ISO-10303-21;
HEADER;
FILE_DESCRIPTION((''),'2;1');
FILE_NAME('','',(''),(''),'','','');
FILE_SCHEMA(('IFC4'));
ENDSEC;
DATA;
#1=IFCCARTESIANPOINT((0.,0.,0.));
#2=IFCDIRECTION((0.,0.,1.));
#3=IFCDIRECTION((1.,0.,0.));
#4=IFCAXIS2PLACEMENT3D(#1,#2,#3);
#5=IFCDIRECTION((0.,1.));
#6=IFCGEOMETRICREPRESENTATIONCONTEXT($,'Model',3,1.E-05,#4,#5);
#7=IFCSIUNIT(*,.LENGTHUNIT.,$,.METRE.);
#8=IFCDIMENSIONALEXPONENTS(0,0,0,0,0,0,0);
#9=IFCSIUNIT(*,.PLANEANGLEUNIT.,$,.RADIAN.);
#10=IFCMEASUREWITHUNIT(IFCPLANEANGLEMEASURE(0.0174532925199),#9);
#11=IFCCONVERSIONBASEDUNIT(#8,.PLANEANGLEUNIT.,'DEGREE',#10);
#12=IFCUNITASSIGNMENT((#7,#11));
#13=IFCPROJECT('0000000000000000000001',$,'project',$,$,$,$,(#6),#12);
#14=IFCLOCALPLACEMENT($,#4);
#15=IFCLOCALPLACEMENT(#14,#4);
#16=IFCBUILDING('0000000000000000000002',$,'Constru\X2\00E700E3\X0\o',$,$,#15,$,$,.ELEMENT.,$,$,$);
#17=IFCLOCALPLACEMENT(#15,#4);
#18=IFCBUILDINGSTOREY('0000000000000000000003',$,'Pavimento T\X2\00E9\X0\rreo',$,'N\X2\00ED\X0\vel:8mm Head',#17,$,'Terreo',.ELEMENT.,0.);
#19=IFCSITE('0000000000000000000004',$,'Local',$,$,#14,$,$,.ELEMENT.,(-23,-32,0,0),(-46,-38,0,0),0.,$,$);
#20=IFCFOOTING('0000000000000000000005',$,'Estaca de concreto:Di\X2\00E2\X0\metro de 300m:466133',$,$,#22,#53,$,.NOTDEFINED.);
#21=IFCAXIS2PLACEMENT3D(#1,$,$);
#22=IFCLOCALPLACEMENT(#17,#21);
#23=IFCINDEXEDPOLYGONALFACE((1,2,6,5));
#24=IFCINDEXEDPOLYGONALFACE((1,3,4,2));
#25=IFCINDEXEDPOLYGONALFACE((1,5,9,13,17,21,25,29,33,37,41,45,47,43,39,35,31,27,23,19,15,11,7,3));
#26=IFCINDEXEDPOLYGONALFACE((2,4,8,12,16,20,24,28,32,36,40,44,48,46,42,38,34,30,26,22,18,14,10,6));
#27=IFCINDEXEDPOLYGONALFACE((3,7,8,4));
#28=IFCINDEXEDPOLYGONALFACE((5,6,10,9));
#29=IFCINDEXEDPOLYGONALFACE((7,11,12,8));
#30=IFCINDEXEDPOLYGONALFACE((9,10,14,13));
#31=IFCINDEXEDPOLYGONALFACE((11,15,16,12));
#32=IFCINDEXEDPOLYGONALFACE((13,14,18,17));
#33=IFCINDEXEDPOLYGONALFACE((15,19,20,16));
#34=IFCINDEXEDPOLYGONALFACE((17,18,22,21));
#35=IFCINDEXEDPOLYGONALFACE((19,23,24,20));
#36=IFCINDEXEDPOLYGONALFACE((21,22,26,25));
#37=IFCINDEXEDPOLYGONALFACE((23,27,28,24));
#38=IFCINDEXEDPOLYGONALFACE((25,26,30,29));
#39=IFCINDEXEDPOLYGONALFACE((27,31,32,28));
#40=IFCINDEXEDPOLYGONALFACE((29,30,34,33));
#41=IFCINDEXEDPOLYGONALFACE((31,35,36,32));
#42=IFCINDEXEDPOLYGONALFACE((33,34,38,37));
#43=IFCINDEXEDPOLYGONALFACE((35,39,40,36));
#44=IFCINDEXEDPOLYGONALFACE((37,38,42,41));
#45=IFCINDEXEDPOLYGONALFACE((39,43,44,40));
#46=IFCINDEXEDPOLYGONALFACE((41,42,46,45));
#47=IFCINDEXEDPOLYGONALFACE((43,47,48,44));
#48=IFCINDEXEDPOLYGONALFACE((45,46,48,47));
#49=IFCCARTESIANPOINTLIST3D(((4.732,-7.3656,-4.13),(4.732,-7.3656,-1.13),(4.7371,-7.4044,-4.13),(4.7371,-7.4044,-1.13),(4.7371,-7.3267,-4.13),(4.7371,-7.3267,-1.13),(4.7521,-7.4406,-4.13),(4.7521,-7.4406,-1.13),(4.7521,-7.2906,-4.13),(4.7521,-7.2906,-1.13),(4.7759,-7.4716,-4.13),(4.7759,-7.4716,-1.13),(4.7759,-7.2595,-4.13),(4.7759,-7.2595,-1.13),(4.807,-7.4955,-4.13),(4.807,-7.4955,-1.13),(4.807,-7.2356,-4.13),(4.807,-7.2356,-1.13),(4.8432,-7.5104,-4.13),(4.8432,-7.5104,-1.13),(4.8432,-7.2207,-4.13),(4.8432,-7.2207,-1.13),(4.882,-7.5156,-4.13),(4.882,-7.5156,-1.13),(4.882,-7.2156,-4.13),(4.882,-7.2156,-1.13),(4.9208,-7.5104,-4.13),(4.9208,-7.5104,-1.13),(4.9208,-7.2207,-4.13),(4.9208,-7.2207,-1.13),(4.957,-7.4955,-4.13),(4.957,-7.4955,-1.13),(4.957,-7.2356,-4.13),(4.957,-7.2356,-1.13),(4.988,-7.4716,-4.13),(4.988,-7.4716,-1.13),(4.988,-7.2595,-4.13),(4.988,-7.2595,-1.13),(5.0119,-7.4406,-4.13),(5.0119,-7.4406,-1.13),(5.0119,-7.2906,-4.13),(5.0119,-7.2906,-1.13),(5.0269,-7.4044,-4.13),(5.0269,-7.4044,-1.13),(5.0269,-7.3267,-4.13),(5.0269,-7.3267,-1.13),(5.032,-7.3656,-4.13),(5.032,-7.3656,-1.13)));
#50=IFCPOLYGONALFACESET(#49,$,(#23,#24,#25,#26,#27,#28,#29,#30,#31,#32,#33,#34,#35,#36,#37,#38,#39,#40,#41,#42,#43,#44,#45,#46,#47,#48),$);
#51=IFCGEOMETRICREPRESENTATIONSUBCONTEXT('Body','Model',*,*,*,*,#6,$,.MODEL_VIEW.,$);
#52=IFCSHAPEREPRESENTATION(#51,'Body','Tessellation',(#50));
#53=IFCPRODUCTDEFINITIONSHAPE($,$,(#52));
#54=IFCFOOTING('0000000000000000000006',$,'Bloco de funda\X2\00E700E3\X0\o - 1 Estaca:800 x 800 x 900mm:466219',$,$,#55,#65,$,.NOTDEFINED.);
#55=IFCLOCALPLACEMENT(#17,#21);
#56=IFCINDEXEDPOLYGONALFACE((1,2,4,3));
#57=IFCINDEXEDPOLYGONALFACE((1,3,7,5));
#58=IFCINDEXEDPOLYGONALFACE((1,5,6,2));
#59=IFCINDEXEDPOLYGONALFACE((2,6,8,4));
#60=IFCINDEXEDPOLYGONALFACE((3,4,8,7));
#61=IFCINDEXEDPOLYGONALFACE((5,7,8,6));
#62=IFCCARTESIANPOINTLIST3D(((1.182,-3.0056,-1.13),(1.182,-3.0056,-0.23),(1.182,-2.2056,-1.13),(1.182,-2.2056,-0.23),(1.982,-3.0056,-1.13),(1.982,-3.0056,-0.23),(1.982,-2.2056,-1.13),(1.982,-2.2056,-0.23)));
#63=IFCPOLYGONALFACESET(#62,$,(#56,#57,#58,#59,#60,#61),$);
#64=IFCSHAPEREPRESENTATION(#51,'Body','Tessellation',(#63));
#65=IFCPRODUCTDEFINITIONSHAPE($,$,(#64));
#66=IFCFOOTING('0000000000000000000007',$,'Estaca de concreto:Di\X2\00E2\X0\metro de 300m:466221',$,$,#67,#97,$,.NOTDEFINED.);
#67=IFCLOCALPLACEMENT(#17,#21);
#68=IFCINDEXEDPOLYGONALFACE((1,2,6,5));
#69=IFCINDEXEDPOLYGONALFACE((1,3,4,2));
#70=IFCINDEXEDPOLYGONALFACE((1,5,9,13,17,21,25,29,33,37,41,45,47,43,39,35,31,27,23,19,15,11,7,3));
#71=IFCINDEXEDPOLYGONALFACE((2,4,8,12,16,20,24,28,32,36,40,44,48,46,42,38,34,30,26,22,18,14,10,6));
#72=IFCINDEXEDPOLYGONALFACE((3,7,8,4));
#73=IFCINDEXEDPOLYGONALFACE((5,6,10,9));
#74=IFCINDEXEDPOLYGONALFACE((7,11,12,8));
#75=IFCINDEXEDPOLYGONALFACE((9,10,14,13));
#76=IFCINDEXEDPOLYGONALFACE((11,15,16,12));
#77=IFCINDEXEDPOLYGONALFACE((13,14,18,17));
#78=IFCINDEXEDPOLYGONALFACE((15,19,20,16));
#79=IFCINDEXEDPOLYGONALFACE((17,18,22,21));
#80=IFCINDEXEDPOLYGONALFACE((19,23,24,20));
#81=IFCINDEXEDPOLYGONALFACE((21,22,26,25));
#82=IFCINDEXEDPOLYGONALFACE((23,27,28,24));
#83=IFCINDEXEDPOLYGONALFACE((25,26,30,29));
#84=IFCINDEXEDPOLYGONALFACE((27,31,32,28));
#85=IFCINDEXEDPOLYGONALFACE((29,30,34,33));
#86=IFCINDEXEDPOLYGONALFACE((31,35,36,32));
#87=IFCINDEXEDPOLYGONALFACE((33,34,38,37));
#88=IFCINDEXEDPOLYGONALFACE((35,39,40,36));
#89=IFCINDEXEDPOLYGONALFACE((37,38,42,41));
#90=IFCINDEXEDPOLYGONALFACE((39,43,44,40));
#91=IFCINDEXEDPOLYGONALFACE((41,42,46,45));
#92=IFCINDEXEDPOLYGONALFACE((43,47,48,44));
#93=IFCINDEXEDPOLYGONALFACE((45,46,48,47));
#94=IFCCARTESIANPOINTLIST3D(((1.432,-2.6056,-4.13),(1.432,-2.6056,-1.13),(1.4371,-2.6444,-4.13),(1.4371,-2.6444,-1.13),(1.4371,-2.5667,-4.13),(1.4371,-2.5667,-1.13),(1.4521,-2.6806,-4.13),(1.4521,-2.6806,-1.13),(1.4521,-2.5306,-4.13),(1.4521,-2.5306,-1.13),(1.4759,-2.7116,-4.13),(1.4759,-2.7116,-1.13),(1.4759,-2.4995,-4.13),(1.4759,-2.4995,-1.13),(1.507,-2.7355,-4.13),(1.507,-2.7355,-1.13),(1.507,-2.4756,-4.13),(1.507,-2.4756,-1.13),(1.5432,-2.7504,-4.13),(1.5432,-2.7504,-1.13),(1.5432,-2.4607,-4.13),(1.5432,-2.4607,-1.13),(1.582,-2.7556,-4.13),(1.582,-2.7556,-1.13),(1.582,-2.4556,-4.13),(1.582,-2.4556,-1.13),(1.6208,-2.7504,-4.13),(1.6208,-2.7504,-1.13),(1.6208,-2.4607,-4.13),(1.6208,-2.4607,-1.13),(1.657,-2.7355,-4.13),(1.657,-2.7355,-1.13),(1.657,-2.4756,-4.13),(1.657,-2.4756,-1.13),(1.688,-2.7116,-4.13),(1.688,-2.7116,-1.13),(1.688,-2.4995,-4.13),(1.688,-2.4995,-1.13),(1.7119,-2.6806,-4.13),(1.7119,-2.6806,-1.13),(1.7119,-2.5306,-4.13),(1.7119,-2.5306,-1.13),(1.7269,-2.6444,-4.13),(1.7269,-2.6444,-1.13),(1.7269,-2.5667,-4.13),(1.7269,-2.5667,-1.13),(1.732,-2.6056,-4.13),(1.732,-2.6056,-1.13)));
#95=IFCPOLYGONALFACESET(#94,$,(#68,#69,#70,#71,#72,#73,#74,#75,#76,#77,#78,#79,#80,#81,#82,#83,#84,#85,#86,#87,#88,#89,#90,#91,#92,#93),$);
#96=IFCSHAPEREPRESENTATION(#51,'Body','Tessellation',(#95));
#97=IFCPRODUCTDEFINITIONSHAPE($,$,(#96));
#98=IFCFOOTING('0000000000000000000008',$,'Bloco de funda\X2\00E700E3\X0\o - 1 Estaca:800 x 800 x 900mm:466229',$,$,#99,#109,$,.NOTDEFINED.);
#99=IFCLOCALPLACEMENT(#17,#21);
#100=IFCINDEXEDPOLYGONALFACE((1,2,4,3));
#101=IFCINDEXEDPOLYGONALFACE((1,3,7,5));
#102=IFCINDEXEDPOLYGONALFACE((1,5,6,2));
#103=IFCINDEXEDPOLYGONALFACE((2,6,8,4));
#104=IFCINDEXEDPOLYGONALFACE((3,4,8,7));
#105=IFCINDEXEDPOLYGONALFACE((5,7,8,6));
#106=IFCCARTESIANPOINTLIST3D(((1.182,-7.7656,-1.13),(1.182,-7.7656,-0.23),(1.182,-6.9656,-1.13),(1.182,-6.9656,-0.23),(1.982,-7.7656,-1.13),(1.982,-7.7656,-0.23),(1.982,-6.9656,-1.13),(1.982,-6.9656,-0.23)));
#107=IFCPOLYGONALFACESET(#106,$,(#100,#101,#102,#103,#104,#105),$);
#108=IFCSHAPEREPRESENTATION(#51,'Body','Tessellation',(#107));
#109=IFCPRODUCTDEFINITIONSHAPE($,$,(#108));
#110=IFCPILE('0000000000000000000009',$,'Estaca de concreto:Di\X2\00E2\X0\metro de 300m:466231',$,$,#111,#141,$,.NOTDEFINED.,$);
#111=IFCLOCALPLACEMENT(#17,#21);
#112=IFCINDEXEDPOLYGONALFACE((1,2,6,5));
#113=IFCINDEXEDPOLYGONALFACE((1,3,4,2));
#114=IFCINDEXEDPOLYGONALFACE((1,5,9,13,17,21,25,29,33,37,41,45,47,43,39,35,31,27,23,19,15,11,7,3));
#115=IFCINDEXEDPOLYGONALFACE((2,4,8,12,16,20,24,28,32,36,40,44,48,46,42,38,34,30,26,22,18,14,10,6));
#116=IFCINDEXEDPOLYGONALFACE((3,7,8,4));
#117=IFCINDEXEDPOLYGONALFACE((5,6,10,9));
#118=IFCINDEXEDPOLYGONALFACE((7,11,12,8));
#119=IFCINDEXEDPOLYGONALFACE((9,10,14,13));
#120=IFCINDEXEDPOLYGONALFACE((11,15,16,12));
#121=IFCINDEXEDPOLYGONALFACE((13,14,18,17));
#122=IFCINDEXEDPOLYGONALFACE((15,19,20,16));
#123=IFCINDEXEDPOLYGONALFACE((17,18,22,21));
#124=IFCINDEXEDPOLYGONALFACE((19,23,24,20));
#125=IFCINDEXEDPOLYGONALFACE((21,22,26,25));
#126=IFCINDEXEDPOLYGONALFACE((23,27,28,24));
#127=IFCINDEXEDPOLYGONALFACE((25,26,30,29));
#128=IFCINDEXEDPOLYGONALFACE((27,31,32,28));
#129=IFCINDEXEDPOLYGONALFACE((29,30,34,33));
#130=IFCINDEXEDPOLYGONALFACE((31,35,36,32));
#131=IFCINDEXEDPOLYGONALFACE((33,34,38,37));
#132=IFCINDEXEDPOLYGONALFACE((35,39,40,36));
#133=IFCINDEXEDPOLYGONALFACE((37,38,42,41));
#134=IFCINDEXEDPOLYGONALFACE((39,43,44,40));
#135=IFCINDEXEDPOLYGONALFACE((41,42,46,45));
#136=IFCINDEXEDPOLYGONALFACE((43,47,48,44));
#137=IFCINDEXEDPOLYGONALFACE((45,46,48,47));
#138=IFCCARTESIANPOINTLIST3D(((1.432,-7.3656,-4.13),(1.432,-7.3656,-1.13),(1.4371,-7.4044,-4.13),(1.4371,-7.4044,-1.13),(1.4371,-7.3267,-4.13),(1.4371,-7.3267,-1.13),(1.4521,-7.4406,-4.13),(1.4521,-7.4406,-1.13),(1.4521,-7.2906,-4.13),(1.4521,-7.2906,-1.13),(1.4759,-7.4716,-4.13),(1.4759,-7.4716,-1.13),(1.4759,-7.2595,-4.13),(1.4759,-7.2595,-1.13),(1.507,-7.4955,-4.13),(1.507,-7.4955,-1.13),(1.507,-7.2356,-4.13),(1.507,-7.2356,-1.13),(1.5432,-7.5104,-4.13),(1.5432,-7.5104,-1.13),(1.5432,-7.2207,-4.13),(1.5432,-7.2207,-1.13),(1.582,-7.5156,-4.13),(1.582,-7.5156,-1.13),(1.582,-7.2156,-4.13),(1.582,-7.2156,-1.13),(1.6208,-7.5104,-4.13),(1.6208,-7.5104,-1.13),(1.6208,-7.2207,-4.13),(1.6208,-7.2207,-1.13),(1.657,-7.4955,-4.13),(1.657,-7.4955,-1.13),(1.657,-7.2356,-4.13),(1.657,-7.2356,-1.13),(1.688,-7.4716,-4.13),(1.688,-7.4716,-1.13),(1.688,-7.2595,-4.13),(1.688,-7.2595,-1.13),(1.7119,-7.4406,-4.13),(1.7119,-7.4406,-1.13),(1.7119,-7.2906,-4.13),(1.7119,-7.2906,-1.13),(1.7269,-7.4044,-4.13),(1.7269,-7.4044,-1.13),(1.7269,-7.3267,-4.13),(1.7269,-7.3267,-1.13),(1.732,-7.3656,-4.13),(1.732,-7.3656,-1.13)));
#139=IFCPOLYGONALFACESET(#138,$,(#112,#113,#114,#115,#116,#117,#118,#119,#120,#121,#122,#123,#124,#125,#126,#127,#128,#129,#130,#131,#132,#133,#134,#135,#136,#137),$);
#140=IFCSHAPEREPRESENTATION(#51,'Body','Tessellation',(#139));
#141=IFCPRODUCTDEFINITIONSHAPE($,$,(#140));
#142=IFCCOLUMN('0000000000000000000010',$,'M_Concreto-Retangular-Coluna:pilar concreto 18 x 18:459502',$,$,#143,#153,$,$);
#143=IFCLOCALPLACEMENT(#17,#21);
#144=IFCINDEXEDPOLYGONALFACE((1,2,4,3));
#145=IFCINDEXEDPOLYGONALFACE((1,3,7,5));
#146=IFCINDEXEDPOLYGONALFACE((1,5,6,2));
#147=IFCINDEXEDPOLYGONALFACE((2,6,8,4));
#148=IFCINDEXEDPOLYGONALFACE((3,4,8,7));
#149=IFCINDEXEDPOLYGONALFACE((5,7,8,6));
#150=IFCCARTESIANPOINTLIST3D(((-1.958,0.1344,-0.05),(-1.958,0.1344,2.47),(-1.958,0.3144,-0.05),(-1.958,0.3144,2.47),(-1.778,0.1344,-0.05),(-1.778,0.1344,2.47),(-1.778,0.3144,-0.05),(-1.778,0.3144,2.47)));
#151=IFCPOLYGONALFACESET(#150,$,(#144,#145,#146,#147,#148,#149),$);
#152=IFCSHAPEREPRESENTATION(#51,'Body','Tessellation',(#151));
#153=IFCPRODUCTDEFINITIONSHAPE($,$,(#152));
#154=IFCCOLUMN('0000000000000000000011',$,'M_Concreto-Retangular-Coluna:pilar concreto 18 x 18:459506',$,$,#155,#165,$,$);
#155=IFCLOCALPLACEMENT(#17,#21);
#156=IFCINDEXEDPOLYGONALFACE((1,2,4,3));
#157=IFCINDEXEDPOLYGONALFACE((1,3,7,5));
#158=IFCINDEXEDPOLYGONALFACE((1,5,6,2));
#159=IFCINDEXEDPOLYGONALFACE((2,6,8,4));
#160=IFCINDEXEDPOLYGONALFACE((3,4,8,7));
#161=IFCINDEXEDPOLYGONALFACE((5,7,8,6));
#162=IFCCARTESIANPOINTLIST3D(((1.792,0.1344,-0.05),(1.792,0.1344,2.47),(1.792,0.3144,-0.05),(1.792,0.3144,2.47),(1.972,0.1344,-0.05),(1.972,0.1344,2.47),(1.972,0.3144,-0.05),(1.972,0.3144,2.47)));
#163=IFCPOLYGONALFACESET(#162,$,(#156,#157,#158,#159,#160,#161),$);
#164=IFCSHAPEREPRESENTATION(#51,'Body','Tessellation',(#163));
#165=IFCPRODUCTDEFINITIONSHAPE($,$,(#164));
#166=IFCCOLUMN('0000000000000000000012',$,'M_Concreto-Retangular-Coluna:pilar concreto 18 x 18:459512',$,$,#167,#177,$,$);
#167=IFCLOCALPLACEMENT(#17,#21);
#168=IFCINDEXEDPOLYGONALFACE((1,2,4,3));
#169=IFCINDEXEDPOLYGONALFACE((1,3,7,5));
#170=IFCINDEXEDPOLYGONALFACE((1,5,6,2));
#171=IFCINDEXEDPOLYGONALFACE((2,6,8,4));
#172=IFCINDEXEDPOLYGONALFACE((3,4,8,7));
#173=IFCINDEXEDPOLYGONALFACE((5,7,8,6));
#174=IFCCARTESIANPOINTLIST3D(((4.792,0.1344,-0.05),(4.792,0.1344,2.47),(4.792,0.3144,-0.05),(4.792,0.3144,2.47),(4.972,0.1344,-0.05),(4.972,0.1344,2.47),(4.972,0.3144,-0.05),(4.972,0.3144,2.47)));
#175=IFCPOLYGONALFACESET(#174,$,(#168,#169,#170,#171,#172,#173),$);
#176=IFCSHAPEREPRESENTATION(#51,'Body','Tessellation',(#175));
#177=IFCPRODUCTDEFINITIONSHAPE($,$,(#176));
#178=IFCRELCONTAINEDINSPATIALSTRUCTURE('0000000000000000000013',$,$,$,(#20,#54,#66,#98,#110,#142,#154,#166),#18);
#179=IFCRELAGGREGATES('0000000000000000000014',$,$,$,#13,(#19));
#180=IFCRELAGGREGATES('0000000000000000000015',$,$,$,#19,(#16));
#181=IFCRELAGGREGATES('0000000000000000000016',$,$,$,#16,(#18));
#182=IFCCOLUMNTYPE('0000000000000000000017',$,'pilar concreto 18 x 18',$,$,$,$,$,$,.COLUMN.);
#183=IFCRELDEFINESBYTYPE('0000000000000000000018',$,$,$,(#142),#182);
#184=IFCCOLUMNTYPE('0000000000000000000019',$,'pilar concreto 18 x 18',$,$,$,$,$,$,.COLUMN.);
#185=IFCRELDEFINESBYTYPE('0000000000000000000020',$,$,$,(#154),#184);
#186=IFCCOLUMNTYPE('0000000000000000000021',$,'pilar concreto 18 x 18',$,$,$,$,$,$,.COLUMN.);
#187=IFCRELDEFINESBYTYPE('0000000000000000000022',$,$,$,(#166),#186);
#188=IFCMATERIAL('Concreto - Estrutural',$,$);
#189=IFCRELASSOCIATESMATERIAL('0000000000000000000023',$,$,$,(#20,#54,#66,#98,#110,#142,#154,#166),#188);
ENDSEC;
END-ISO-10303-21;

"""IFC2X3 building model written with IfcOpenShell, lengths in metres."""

from ifc_helpers import new_model, entity, si_unit, converted_unit, point, direction, frame, frame_2d, origin_with_axes, origin_2d_with_axis, place, context, subcontext, project, spatial, polyline, circle_curve, parameter, trimmed, segment, composite_curve, rectangle, outline, extrude, material, type_object, element, save


model = new_model("IFC2X3")

# Units and contexts
model_context = context("Model", 3, precision=1e-05, world=origin_with_axes(), true_north=direction((0.0, 1.0)))
body_context = subcontext(model_context, "Body", "Model", "MODEL_VIEW")
ifc_project = project(units=[si_unit("LENGTHUNIT", "METRE"), converted_unit("PLANEANGLEUNIT", "DEGREE", entity("IfcPlaneAngleMeasure", 0.0174532925199), si_unit("PLANEANGLEUNIT", "RADIAN"), dimensions=[0, 0, 0, 0, 0, 0, 0])], contexts=[model_context])

# Site, building, storey
site_placement = place(None, origin_with_axes())
site = spatial("IfcSite", under=ifc_project, at=site_placement, Name="Local", CompositionType="ELEMENT", RefLatitude=(-23, -32, 0, 0), RefLongitude=(-46, -38, 0, 0), RefElevation=0.0)
building_placement = place(site_placement, origin_with_axes())
building = spatial("IfcBuilding", under=site, at=building_placement, Name="Construção", CompositionType="ELEMENT")
storey_placement = place(building_placement, origin_with_axes())
storey = spatial("IfcBuildingStorey", under=building, at=storey_placement, Name="Pavimento Térreo", ObjectType="Nível:8mm Head", LongName="Terreo", CompositionType="ELEMENT", Elevation=0.0)

# Footings
ifc_material = material(Name="Concreto - Estrutural")
footing_1_placement = place(storey_placement, frame((5.032, -7.3656, -1.13), z_axis=(0.0, 0.0, 1.0), x_axis=(1.0, 0.0, 0.0)))
element("IfcFooting", 1, at=footing_1_placement, inside=storey, material=ifc_material, Name="Estaca de concreto:Diâmetro de 300m:466133", PredefinedType="NOTDEFINED", context=body_context, shape_type="SweptSolid", body=[
    extrude(outline(composite_curve([segment(trimmed(circle_curve(frame_2d((-0.15, 0.0), x_axis=(1.0, 0.0)), 0.15), [point((0.0, 0.0)), parameter(0.0)], [point((-0.15, 0.15)), parameter(90.0)], True, "CARTESIAN"), True, "CONTINUOUS"), segment(trimmed(circle_curve(frame_2d((-0.15, 0.0), x_axis=(0.0, 1.0)), 0.15), [point((-0.15, 0.15)), parameter(0.0)], [point((-0.3, 0.0)), parameter(90.0)], True, "CARTESIAN"), True, "CONTINUOUS"), segment(trimmed(circle_curve(frame_2d((-0.15, 0.0), x_axis=(-1.0, 0.0)), 0.15), [point((-0.3, 0.0)), parameter(0.0)], [point((-0.15, -0.15)), parameter(90.0)], True, "CARTESIAN"), True, "CONTINUOUS"), segment(trimmed(circle_curve(frame_2d((-0.15, 0.0), x_axis=(0.0, -1.0)), 0.15), [point((-0.15, -0.15)), parameter(0.0)], [point((0.0, 0.0)), parameter(90.0)], True, "CARTESIAN"), True, "CONTINUOUS")], self_intersect=False)), frame((0.0, 0.0, -3.0), z_axis=(0.0, 0.0, 1.0), x_axis=(1.0, 0.0, 0.0)), (0.0, 0.0, 1.0), 3.0),
])
footing_2_placement = place(storey_placement, frame((1.182, -2.2056, -0.23), z_axis=(0.0, 0.0, 1.0), x_axis=(1.0, 0.0, 0.0)))
element("IfcFooting", 2, at=footing_2_placement, inside=storey, material=ifc_material, Name="Bloco de fundação - 1 Estaca:800 x 800 x 900mm:466219", PredefinedType="NOTDEFINED", context=body_context, shape_type="SweptSolid", body=[
    extrude(outline(polyline([(0.0, 0.0), (0.0, -0.8), (0.8, -0.8), (0.8, 0.0), (0.0, 0.0)])), frame((0.0, 0.0, -0.9), z_axis=(0.0, 0.0, 1.0), x_axis=(1.0, 0.0, 0.0)), (0.0, 0.0, 1.0), 0.9),
])
footing_3_placement = place(storey_placement, frame((1.732, -2.6056, -1.13), z_axis=(0.0, 0.0, 1.0), x_axis=(1.0, 0.0, 0.0)))
element("IfcFooting", 3, at=footing_3_placement, inside=storey, material=ifc_material, Name="Estaca de concreto:Diâmetro de 300m:466221", PredefinedType="NOTDEFINED", context=body_context, shape_type="SweptSolid", body=[
    extrude(outline(composite_curve([segment(trimmed(circle_curve(frame_2d((-0.15, 0.0), x_axis=(1.0, 0.0)), 0.15), [point((0.0, 0.0)), parameter(0.0)], [point((-0.15, 0.15)), parameter(90.0)], True, "CARTESIAN"), True, "CONTINUOUS"), segment(trimmed(circle_curve(frame_2d((-0.15, 0.0), x_axis=(0.0, 1.0)), 0.15), [point((-0.15, 0.15)), parameter(0.0)], [point((-0.3, 0.0)), parameter(90.0)], True, "CARTESIAN"), True, "CONTINUOUS"), segment(trimmed(circle_curve(frame_2d((-0.15, 0.0), x_axis=(-1.0, 0.0)), 0.15), [point((-0.3, 0.0)), parameter(0.0)], [point((-0.15, -0.15)), parameter(90.0)], True, "CARTESIAN"), True, "CONTINUOUS"), segment(trimmed(circle_curve(frame_2d((-0.15, 0.0), x_axis=(0.0, -1.0)), 0.15), [point((-0.15, -0.15)), parameter(0.0)], [point((0.0, 0.0)), parameter(90.0)], True, "CARTESIAN"), True, "CONTINUOUS")], self_intersect=False)), frame((0.0, 0.0, -3.0), z_axis=(0.0, 0.0, 1.0), x_axis=(1.0, 0.0, 0.0)), (0.0, 0.0, 1.0), 3.0),
])
footing_4_placement = place(storey_placement, frame((1.182, -6.9656, -0.23), z_axis=(0.0, 0.0, 1.0), x_axis=(1.0, 0.0, 0.0)))
element("IfcFooting", 4, at=footing_4_placement, inside=storey, material=ifc_material, Name="Bloco de fundação - 1 Estaca:800 x 800 x 900mm:466229", PredefinedType="NOTDEFINED", context=body_context, shape_type="SweptSolid", body=[
    extrude(outline(polyline([(0.0, 0.0), (0.0, -0.8), (0.8, -0.8), (0.8, 0.0), (0.0, 0.0)])), frame((0.0, 0.0, -0.9), z_axis=(0.0, 0.0, 1.0), x_axis=(1.0, 0.0, 0.0)), (0.0, 0.0, 1.0), 0.9),
])

# Pile
pile_placement = place(storey_placement, frame((1.732, -7.3656, -1.13), z_axis=(0.0, 0.0, 1.0), x_axis=(1.0, 0.0, 0.0)))
element("IfcPile", 5, at=pile_placement, inside=storey, material=ifc_material, Name="Estaca de concreto:Diâmetro de 300m:466231", PredefinedType="NOTDEFINED", context=body_context, shape_type="SweptSolid", body=[
    extrude(outline(composite_curve([segment(trimmed(circle_curve(frame_2d((-0.15, 0.0), x_axis=(1.0, 0.0)), 0.15), [point((0.0, 0.0)), parameter(0.0)], [point((-0.15, 0.15)), parameter(90.0)], True, "CARTESIAN"), True, "CONTINUOUS"), segment(trimmed(circle_curve(frame_2d((-0.15, 0.0), x_axis=(0.0, 1.0)), 0.15), [point((-0.15, 0.15)), parameter(0.0)], [point((-0.3, 0.0)), parameter(90.0)], True, "CARTESIAN"), True, "CONTINUOUS"), segment(trimmed(circle_curve(frame_2d((-0.15, 0.0), x_axis=(-1.0, 0.0)), 0.15), [point((-0.3, 0.0)), parameter(0.0)], [point((-0.15, -0.15)), parameter(90.0)], True, "CARTESIAN"), True, "CONTINUOUS"), segment(trimmed(circle_curve(frame_2d((-0.15, 0.0), x_axis=(0.0, -1.0)), 0.15), [point((-0.15, -0.15)), parameter(0.0)], [point((0.0, 0.0)), parameter(90.0)], True, "CARTESIAN"), True, "CONTINUOUS")], self_intersect=False)), frame((0.0, 0.0, -3.0), z_axis=(0.0, 0.0, 1.0), x_axis=(1.0, 0.0, 0.0)), (0.0, 0.0, 1.0), 3.0),
])

# Columns
column_type_1 = type_object("IfcColumnType", Name="pilar concreto 18 x 18", PredefinedType="COLUMN")
column_1_placement = place(storey_placement, frame((-1.868, 0.2244, -0.05), z_axis=(0.0, 0.0, 1.0), x_axis=(0.0, -1.0, 0.0)))
element("IfcColumn", 6, at=column_1_placement, inside=storey, type_object=column_type_1, material=ifc_material, Name="M_Concreto-Retangular-Coluna:pilar concreto 18 x 18:459502", context=body_context, shape_type="SweptSolid", body=[
    extrude(rectangle(XDim=0.18, YDim=0.18, at=origin_2d_with_axis()), origin_with_axes(), (0.0, 0.0, 1.0), 2.52),
])
column_type_2 = type_object("IfcColumnType", Name="pilar concreto 18 x 18", PredefinedType="COLUMN")
column_2_placement = place(storey_placement, frame((1.882, 0.2244, -0.05), z_axis=(0.0, 0.0, 1.0), x_axis=(0.0, -1.0, 0.0)))
element("IfcColumn", 7, at=column_2_placement, inside=storey, type_object=column_type_2, material=ifc_material, Name="M_Concreto-Retangular-Coluna:pilar concreto 18 x 18:459506", context=body_context, shape_type="SweptSolid", body=[
    extrude(rectangle(XDim=0.18, YDim=0.18, at=origin_2d_with_axis()), origin_with_axes(), (0.0, 0.0, 1.0), 2.52),
])
column_type_3 = type_object("IfcColumnType", Name="pilar concreto 18 x 18", PredefinedType="COLUMN")
column_3_placement = place(storey_placement, frame((4.882, 0.2244, -0.05), z_axis=(0.0, 0.0, 1.0), x_axis=(0.0, -1.0, 0.0)))
element("IfcColumn", 8, at=column_3_placement, inside=storey, type_object=column_type_3, material=ifc_material, Name="M_Concreto-Retangular-Coluna:pilar concreto 18 x 18:459512", context=body_context, shape_type="SweptSolid", body=[
    extrude(rectangle(XDim=0.18, YDim=0.18, at=origin_2d_with_axis()), origin_with_axes(), (0.0, 0.0, 1.0), 2.52),
])

save(model, "model.ifc")
